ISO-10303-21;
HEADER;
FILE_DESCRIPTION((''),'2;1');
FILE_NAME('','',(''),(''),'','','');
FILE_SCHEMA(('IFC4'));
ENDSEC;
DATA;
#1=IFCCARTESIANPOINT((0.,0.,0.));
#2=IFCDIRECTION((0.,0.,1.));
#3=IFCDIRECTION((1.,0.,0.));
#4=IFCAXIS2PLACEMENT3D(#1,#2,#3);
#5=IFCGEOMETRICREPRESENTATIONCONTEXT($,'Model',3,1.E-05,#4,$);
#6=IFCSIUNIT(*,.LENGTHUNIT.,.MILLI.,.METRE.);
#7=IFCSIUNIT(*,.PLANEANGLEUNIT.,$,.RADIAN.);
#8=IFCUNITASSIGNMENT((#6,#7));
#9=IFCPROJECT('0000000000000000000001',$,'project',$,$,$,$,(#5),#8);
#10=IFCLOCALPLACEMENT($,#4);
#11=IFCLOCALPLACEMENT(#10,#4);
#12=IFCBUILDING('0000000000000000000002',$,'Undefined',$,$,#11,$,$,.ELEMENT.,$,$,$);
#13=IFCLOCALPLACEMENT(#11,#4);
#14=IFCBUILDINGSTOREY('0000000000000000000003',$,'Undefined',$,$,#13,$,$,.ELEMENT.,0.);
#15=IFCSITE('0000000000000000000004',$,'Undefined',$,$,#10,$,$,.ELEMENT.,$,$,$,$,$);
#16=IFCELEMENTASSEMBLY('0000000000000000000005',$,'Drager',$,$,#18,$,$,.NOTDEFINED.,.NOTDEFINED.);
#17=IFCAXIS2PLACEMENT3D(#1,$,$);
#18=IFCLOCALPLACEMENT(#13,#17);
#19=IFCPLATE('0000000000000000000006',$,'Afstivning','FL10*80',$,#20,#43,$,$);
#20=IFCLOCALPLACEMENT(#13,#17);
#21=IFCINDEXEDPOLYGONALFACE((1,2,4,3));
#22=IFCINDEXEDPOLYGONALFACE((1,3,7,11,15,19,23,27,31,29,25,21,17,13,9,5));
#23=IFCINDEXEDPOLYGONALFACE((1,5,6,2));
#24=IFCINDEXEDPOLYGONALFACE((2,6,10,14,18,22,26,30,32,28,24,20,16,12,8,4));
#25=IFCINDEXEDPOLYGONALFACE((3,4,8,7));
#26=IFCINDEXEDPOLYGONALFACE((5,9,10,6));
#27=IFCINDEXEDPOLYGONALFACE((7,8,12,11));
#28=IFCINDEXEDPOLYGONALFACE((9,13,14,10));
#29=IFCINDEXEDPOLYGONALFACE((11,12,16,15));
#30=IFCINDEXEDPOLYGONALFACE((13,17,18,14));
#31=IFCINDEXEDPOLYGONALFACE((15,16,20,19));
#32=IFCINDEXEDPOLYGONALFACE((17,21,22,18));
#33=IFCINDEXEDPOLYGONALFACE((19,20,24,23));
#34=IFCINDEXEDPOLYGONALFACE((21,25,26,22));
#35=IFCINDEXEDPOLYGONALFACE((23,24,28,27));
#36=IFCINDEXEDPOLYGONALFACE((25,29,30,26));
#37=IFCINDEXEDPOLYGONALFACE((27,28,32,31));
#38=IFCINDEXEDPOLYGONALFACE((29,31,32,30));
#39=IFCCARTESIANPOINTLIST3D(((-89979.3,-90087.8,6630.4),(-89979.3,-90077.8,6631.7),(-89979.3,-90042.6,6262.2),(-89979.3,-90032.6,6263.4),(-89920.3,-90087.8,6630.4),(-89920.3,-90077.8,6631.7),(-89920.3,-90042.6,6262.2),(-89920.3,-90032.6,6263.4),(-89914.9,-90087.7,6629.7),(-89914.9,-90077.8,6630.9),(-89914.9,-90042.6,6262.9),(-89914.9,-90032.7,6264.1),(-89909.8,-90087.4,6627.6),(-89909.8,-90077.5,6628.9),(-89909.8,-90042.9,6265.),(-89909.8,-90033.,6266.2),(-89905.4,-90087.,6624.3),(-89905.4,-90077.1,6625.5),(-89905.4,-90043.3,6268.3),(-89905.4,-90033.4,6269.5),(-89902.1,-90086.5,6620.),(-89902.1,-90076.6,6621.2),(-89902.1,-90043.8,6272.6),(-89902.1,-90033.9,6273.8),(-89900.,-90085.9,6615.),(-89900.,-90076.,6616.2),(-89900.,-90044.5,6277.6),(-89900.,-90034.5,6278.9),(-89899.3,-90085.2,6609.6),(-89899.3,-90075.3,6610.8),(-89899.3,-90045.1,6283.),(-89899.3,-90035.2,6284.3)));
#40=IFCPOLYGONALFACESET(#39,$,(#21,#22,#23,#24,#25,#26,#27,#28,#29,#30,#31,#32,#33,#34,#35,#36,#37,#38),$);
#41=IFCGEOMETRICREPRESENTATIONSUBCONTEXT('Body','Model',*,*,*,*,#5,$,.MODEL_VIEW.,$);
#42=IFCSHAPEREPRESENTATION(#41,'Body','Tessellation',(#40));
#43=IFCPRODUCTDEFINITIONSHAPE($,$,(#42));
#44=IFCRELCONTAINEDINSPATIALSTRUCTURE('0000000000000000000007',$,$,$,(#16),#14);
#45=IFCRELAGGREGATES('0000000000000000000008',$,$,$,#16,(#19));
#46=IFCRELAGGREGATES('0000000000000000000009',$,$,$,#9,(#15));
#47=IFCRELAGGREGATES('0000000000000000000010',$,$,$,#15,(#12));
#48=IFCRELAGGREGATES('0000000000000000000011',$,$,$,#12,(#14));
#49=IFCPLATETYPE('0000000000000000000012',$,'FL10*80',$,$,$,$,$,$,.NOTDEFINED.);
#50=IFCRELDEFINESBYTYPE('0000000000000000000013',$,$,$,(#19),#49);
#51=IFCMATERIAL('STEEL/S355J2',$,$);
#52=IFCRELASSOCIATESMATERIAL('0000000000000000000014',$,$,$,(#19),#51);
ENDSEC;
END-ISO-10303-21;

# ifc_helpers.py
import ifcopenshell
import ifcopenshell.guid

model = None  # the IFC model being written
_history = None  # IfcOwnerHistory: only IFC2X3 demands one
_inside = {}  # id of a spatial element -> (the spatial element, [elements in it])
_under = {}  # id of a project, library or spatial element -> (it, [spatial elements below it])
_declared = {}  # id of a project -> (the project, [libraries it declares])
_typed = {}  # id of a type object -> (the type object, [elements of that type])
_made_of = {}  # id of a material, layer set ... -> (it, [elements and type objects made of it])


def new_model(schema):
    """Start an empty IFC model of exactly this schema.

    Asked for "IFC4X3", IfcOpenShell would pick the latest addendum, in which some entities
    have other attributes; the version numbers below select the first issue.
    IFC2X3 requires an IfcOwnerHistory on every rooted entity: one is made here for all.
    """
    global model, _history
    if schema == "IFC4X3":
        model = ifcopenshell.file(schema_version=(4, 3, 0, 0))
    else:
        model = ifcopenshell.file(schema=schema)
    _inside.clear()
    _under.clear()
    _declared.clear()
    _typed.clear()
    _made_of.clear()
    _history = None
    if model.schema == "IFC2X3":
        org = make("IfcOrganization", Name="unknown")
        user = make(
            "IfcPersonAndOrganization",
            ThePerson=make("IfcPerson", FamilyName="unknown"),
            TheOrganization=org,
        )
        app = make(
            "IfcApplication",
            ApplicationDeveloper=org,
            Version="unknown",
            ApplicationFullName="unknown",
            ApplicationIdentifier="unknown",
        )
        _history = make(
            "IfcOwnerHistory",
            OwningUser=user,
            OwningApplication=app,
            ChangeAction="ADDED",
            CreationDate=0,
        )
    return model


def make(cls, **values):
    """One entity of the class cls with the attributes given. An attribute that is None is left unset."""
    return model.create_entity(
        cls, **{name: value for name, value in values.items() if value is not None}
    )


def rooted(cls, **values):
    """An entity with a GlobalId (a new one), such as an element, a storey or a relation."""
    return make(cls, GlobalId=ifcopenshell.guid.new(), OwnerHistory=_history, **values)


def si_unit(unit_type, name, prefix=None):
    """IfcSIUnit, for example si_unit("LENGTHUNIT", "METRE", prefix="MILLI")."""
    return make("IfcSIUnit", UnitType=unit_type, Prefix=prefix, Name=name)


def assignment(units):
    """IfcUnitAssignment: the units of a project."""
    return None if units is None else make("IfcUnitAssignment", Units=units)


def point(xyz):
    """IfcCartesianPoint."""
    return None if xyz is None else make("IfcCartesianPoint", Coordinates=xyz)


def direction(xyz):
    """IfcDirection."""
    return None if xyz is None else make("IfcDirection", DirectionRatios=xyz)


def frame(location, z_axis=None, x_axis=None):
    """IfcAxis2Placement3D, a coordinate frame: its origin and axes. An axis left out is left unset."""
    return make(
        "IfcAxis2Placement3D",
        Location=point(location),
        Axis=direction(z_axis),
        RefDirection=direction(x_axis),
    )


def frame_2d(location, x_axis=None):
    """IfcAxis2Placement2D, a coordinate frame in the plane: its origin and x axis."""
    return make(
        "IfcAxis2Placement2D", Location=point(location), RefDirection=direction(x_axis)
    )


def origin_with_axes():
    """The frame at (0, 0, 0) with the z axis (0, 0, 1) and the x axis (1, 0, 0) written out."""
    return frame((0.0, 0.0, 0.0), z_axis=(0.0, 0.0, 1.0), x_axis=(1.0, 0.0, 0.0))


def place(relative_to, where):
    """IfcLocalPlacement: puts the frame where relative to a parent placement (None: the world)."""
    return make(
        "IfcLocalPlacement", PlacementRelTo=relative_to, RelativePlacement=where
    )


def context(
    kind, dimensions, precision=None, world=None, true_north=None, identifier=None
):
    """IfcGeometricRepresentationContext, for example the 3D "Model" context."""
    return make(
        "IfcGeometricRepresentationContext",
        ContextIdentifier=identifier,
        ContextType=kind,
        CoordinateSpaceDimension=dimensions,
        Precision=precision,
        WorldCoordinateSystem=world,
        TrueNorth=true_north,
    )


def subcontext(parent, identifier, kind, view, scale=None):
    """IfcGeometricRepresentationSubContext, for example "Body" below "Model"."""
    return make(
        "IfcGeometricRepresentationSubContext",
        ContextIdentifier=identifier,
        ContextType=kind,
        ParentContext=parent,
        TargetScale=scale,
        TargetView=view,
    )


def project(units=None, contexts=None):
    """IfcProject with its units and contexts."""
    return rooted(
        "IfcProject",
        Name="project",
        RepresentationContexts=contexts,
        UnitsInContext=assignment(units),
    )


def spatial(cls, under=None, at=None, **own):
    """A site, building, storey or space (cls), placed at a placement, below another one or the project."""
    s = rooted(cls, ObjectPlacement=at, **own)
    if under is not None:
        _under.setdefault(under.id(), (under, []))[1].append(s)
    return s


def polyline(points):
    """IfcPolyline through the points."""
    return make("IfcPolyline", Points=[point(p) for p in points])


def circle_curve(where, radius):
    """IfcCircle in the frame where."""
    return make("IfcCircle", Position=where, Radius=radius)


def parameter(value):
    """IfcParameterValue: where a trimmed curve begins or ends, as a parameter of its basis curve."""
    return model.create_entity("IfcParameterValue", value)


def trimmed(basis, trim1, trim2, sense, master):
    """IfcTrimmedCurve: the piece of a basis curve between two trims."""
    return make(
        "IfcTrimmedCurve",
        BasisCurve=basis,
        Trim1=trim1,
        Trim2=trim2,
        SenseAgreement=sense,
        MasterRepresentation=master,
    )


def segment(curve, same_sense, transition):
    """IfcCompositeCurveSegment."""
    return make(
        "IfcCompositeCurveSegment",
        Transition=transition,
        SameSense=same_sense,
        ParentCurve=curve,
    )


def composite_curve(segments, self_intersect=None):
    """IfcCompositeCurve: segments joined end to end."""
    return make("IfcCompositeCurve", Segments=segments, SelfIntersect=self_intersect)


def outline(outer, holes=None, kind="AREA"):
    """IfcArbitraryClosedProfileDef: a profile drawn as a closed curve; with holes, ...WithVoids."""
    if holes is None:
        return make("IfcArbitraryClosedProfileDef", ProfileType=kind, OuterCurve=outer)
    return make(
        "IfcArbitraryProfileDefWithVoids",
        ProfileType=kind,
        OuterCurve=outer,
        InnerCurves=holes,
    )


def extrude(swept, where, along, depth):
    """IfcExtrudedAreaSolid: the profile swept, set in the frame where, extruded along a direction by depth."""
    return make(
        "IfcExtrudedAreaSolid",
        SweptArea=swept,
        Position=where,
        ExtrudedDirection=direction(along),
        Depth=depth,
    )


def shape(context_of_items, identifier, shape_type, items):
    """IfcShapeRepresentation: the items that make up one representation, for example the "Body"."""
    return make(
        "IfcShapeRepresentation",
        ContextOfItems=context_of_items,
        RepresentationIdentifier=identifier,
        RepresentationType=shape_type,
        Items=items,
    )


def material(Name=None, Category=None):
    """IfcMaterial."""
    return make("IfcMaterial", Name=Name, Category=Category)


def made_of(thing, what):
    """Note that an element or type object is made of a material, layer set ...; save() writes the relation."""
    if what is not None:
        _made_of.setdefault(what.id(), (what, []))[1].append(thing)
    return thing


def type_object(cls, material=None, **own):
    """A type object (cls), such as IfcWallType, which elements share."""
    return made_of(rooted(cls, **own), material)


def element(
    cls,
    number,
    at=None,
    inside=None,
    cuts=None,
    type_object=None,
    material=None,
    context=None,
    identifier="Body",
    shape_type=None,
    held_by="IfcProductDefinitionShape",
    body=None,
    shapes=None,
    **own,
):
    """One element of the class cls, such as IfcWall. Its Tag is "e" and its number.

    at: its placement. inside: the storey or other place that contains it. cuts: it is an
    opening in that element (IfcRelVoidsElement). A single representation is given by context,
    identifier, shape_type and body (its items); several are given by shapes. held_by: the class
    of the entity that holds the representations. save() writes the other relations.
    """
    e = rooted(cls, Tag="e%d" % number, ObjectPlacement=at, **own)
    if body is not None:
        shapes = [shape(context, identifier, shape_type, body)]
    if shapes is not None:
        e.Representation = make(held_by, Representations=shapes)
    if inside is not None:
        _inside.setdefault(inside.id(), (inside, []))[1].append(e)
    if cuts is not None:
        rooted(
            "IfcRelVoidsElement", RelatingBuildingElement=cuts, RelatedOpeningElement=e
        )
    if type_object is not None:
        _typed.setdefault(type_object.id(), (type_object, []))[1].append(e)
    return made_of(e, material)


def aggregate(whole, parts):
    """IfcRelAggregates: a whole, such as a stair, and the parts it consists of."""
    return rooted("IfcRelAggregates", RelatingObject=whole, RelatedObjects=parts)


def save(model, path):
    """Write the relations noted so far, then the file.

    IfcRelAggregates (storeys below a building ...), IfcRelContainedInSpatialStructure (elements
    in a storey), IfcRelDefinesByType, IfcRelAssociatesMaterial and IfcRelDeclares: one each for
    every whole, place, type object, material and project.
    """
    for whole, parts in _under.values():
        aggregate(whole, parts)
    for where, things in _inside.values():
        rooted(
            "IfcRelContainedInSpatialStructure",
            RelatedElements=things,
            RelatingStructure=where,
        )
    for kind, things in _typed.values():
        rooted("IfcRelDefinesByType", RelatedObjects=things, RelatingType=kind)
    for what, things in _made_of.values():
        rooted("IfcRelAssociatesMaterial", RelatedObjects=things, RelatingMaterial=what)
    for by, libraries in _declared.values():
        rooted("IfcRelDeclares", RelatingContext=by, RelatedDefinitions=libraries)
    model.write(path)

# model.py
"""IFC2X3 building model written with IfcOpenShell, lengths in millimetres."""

from ifc_helpers import new_model, si_unit, frame, frame_2d, origin_with_axes, place, context, subcontext, project, spatial, polyline, circle_curve, parameter, trimmed, segment, composite_curve, outline, extrude, material, type_object, element, aggregate, save


model = new_model("IFC2X3")

# Units and contexts
model_context = context("Model", 3, precision=1e-05, world=origin_with_axes())
body_context = subcontext(model_context, "Body", "Model", "MODEL_VIEW")
ifc_project = project(units=[si_unit("LENGTHUNIT", "METRE", prefix="MILLI"), si_unit("PLANEANGLEUNIT", "RADIAN")], contexts=[model_context])

# Site, building, storey
site_placement = place(None, origin_with_axes())
site = spatial("IfcSite", under=ifc_project, at=site_placement, Name="Undefined", CompositionType="ELEMENT")
building_placement = place(site_placement, origin_with_axes())
building = spatial("IfcBuilding", under=site, at=building_placement, Name="Undefined", CompositionType="ELEMENT")
storey_placement = place(building_placement, origin_with_axes())
storey = spatial("IfcBuildingStorey", under=building, at=storey_placement, Name="Undefined", CompositionType="ELEMENT", Elevation=0.0)

# Shared definitions
ifc_material_1 = material(Name="STEEL/S355J2")

# Element assembly, plate
assembly_1_placement = place(storey_placement, origin_with_axes())
assembly_1 = element("IfcElementAssembly", 1, at=assembly_1_placement, inside=storey, Name="Drager", AssemblyPlace="NOTDEFINED", PredefinedType="NOTDEFINED")
plate_type_1 = type_object("IfcPlateType", Name="FL10*80", PredefinedType="NOTDEFINED")
plate_1_placement = place(assembly_1_placement, frame((-89979.3, -90037.6, 6262.8), z_axis=(0.0, -0.992546, -0.121869), x_axis=(1.0, 0.0, 0.0)))
plate_1 = element("IfcPlate", 2, at=plate_1_placement, type_object=plate_type_1, material=ifc_material_1, Name="Afstivning", Description="FL10*80", context=body_context, shape_type="SweptSolid", body=[
    extrude(outline(composite_curve([segment(polyline([(0.0, 0.0), (59.0, 0.0)]), True, "CONTINUOUS"), segment(trimmed(circle_curve(frame_2d((59.0, 21.0), x_axis=(0.0, -1.0)), 21.0), [parameter(0.0)], [parameter(1.570796)], True, "PARAMETER"), True, "CONTINUOUS"), segment(polyline([(80.0, 21.0), (80.0, 350.0)]), True, "CONTINUOUS"), segment(trimmed(circle_curve(frame_2d((59.0, 350.0), x_axis=(1.0, 0.0)), 21.0), [parameter(0.0)], [parameter(1.570796)], True, "PARAMETER"), True, "CONTINUOUS"), segment(polyline([(59.0, 371.0), (0.0, 371.0), (0.0, 0.0)]), True, "CONTINUOUS")], self_intersect=True)), frame((0.0, 0.0, -5.0), z_axis=(0.0, 0.0, 1.0), x_axis=(1.0, 0.0, 0.0)), (0.0, 0.0, 1.0), 10.0),
])

aggregate(assembly_1, [plate_1])

save(model, "model.ifc")
